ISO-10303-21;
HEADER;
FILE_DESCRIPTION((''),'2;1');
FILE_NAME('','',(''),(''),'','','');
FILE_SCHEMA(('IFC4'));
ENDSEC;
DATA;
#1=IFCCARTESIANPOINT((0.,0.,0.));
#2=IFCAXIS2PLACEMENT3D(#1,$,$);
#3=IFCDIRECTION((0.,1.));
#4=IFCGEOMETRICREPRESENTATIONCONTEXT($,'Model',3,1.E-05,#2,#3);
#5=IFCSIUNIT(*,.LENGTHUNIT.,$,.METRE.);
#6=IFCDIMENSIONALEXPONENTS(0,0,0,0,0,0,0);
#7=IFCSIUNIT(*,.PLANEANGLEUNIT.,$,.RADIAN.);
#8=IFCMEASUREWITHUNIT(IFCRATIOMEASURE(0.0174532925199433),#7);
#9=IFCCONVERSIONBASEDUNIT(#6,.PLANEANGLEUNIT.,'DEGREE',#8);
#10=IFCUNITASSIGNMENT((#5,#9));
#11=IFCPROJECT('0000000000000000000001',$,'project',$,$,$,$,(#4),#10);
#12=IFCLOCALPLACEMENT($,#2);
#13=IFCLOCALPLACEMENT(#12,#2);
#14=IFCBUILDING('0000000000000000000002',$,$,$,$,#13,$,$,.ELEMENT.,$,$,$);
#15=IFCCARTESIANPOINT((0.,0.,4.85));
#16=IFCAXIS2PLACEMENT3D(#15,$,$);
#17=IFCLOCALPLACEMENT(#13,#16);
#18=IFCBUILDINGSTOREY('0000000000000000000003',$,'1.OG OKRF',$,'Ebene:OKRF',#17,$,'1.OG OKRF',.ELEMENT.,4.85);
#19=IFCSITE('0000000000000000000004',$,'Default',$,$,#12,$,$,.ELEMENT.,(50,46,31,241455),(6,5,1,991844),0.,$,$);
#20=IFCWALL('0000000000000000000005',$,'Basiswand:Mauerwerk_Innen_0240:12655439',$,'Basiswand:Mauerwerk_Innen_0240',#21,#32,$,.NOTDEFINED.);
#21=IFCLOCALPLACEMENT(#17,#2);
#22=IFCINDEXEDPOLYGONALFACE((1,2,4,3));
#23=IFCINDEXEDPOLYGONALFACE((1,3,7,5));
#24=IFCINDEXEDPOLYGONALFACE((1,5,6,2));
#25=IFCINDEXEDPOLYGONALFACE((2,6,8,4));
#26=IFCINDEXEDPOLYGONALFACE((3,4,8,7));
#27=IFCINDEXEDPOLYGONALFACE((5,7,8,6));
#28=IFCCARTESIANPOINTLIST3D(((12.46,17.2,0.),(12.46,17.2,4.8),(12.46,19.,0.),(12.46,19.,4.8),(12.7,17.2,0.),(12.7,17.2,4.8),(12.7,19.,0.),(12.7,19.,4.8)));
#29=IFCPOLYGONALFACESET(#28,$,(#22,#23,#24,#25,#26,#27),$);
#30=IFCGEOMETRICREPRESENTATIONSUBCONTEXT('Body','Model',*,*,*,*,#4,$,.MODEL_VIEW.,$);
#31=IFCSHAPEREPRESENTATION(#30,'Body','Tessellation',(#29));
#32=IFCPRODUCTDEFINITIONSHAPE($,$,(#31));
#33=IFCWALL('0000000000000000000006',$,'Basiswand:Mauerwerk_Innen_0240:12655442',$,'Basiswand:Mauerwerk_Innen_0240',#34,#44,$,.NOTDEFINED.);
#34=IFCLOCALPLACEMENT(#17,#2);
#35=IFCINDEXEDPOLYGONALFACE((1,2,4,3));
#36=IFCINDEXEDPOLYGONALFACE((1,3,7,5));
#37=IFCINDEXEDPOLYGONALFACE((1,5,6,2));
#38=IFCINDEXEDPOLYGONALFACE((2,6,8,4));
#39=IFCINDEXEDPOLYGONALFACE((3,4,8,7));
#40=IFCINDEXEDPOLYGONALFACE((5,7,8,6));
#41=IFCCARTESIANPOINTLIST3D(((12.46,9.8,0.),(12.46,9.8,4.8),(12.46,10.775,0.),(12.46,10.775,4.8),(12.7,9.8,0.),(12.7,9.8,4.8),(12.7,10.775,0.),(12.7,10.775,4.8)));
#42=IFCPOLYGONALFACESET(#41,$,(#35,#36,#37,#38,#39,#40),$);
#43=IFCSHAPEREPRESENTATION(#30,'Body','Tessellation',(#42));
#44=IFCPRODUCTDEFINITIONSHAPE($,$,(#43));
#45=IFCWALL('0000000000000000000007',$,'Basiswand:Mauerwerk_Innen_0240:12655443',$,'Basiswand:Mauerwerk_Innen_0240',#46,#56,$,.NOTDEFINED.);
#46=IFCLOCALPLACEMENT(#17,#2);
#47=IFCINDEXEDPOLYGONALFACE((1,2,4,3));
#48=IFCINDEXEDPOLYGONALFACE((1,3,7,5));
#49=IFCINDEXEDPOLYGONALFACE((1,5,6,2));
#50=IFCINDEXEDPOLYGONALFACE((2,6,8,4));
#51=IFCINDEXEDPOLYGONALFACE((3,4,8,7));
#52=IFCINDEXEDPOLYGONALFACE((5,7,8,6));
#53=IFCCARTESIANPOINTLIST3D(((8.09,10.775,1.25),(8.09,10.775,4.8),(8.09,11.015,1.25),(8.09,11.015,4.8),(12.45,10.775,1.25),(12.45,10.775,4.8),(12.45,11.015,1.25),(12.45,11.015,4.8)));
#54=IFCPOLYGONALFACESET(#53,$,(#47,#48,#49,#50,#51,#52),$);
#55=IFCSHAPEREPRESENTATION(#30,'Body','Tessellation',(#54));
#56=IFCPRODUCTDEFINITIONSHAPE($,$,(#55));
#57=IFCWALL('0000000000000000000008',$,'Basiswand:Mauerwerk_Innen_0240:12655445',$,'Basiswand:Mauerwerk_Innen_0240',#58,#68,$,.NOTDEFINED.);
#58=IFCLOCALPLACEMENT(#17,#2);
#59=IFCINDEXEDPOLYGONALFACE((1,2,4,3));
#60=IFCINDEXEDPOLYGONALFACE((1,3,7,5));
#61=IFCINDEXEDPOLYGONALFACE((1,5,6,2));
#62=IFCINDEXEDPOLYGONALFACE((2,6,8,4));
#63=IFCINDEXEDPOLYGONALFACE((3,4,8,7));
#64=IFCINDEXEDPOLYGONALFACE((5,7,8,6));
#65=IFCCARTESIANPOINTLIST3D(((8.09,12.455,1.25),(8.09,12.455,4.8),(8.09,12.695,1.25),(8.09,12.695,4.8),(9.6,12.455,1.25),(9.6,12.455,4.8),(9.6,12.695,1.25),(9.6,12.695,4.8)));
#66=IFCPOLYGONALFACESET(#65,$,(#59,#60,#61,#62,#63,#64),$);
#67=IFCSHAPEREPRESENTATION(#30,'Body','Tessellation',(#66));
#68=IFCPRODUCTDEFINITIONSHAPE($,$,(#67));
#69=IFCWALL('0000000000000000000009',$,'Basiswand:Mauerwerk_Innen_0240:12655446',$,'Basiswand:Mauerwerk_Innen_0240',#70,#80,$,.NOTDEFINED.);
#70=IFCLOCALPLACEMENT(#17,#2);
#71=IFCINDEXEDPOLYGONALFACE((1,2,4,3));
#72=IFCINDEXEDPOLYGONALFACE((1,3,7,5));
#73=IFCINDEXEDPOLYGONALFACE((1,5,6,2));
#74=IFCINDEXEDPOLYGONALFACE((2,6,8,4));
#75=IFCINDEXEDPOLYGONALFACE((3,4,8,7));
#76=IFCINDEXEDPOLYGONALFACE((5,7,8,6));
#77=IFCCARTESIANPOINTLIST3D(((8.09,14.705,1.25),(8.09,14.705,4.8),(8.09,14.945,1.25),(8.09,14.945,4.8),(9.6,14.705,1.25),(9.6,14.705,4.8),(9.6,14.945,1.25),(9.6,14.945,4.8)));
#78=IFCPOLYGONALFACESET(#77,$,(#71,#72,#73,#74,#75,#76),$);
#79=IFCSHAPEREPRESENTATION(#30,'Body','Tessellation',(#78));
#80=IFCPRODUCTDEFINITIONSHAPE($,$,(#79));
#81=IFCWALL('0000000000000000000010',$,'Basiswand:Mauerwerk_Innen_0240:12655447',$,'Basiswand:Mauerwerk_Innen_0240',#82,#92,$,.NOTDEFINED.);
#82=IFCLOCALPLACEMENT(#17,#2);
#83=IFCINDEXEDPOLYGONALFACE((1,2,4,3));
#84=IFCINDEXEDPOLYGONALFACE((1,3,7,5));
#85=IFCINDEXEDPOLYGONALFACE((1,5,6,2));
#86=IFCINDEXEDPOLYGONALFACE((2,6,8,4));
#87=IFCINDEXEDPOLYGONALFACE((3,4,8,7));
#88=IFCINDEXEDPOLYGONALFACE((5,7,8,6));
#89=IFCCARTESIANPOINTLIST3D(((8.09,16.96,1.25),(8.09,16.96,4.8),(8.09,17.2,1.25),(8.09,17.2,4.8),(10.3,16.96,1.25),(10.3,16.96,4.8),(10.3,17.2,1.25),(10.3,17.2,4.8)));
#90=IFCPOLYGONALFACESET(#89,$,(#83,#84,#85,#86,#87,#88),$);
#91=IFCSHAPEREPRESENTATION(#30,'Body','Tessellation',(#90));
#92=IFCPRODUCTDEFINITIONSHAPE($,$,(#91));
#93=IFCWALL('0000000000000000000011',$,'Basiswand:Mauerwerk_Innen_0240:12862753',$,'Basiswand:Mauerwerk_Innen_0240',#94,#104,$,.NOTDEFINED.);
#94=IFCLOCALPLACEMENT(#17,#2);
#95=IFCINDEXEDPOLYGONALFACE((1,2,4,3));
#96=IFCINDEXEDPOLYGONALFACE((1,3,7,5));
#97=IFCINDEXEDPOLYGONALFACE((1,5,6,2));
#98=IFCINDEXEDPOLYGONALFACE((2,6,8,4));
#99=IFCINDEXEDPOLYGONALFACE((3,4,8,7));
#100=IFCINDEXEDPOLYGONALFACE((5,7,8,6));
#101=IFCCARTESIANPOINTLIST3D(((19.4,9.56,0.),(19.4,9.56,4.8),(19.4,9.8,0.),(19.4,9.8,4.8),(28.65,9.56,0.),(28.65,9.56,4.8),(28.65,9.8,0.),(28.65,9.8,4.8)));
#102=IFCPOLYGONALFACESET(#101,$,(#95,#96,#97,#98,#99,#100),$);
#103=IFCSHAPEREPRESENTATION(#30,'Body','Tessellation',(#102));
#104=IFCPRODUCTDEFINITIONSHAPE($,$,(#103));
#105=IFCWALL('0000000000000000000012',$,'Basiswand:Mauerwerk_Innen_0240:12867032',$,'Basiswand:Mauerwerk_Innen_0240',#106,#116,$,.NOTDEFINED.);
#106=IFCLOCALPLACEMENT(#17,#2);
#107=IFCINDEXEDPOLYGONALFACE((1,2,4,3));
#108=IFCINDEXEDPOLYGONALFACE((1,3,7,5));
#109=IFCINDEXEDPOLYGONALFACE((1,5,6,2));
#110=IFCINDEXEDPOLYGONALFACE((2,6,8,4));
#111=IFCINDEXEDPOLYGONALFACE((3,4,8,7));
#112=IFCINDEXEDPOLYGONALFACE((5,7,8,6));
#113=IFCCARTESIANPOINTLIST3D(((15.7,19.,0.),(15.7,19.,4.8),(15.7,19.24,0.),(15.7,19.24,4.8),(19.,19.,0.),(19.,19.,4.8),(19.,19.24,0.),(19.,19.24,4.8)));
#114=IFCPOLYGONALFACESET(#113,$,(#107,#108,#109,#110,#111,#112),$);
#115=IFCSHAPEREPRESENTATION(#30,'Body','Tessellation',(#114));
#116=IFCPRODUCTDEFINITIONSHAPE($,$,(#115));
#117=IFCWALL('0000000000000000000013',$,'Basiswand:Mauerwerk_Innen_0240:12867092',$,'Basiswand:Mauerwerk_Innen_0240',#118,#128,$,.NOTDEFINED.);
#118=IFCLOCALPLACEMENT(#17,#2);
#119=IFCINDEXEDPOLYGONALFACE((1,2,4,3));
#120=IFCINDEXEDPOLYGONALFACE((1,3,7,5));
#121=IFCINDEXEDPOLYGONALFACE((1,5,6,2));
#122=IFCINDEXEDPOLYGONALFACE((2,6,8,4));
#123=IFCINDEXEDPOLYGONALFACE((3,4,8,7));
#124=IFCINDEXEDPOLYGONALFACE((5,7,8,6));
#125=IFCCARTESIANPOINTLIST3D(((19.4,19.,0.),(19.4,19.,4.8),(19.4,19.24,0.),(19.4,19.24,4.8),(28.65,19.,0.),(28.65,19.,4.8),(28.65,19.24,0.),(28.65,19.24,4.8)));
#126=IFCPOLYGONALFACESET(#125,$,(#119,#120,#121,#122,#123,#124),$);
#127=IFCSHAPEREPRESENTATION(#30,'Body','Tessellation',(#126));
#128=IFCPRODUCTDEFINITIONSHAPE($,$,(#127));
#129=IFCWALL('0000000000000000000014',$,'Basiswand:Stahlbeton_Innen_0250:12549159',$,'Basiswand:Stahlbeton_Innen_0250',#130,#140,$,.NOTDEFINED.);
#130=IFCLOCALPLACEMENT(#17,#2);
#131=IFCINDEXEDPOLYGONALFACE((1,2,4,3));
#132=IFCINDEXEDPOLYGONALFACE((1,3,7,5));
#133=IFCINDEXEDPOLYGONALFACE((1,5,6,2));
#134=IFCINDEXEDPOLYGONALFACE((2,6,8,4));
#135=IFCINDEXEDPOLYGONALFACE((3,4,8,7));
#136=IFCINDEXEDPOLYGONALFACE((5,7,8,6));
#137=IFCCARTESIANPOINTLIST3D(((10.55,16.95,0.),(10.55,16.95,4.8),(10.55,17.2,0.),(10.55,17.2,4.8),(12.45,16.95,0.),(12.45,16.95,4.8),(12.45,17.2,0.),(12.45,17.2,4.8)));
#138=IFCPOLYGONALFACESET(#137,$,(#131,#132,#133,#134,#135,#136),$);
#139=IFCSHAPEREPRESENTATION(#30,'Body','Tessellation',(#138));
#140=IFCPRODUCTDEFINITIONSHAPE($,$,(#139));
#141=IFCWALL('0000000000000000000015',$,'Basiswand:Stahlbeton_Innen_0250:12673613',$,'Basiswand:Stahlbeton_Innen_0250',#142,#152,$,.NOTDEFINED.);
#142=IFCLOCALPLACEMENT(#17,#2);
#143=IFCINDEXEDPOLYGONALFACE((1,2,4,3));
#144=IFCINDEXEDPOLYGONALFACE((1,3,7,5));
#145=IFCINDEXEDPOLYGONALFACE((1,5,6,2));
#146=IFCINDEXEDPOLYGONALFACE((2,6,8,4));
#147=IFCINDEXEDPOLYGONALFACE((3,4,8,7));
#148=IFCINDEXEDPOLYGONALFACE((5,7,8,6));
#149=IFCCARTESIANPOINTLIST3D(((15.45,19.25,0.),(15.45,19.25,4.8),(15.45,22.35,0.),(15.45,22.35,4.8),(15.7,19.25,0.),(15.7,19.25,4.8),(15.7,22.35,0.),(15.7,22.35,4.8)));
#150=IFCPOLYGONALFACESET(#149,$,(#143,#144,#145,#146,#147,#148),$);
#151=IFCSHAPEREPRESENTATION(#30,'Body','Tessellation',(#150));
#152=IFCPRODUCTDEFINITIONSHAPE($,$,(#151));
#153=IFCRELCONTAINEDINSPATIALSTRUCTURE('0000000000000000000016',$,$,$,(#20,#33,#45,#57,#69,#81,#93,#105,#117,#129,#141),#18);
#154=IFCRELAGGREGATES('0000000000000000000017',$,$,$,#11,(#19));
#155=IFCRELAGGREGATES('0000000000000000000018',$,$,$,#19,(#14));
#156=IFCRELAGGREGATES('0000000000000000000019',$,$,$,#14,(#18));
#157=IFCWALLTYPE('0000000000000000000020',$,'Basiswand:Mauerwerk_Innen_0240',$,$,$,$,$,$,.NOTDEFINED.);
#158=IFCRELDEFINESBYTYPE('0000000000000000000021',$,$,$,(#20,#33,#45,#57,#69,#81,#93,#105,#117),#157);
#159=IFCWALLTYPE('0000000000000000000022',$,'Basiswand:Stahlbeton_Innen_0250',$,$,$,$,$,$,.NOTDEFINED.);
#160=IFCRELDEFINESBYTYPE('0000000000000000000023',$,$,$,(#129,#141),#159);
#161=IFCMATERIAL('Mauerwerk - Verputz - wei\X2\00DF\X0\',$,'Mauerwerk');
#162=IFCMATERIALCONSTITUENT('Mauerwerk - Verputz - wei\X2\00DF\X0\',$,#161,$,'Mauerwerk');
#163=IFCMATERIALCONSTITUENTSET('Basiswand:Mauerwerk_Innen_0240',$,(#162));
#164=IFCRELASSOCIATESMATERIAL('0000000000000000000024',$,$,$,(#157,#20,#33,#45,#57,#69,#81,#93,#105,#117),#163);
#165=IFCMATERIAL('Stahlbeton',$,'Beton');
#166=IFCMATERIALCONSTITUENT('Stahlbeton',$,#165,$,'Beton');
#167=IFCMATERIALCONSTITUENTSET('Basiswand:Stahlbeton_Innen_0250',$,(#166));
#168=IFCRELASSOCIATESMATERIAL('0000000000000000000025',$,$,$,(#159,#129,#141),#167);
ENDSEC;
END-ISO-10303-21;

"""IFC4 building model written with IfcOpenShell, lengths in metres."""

from ifc_helpers import new_model, entity, si_unit, converted_unit, direction, frame, origin, place, context, subcontext, project, spatial, indexed_curve, outline, extrude, material, constituent, constituent_set, type_object, element, save


model = new_model("IFC4")

# Units and contexts
model_context = context("Model", 3, precision=1e-05, world=origin(), true_north=direction((0.0, 1.0)))
body_context = subcontext(model_context, "Body", "Model", "MODEL_VIEW")
ifc_project = project(units=[si_unit("LENGTHUNIT", "METRE"), converted_unit("PLANEANGLEUNIT", "DEGREE", entity("IfcRatioMeasure", 0.0174532925199433), si_unit("PLANEANGLEUNIT", "RADIAN"), dimensions=[0, 0, 0, 0, 0, 0, 0])], contexts=[model_context])

# Site, building, storey
site_placement = place(None, origin())
site = spatial("IfcSite", under=ifc_project, at=site_placement, Name="Default", CompositionType="ELEMENT", RefLatitude=(50, 46, 31, 241455), RefLongitude=(6, 5, 1, 991844), RefElevation=0.0)
building_placement = place(site_placement, origin())
building = spatial("IfcBuilding", under=site, at=building_placement, CompositionType="ELEMENT")
storey_placement = place(building_placement, frame((0.0, 0.0, 4.85)))
storey = spatial("IfcBuildingStorey", under=building, at=storey_placement, Name="1.OG OKRF", ObjectType="Ebene:OKRF", LongName="1.OG OKRF", CompositionType="ELEMENT", Elevation=4.85)

# Walls
ifc_material_1 = material(Name="Mauerwerk - Verputz - weiß", Category="Mauerwerk")
ifc_constituent_1 = constituent(ifc_material_1, Name="Mauerwerk - Verputz - weiß", Category="Mauerwerk")
ifc_constituent_set_1 = constituent_set(constituents=[ifc_constituent_1], Name="Basiswand:Mauerwerk_Innen_0240")
wall_type_1 = type_object("IfcWallType", Name="Basiswand:Mauerwerk_Innen_0240", PredefinedType="NOTDEFINED", material=ifc_constituent_set_1)
wall_1_placement = place(storey_placement, frame((12.58, 17.2, 0.0), z_axis=(0.0, 0.0, 1.0), x_axis=(0.0, 1.0, 0.0)))
element("IfcWall", 1, at=wall_1_placement, inside=storey, type_object=wall_type_1, material=ifc_constituent_set_1, Name="Basiswand:Mauerwerk_Innen_0240:12655439", ObjectType="Basiswand:Mauerwerk_Innen_0240", PredefinedType="NOTDEFINED", context=body_context, shape_type="SweptSolid", body=[
    extrude(outline(indexed_curve([(-0.12, -0.9), (0.12, -0.9), (0.12, 0.9), (-0.12, 0.9), (-0.12, -0.9)], self_intersect=False)), frame((0.9, 0.0, 0.0), z_axis=(0.0, 0.0, 1.0), x_axis=(0.0, 1.0, 0.0)), (0.0, 0.0, 1.0), 4.8),
])
wall_2_placement = place(storey_placement, frame((12.58, 9.8, 0.0), z_axis=(0.0, 0.0, 1.0), x_axis=(0.0, 1.0, 0.0)))
element("IfcWall", 2, at=wall_2_placement, inside=storey, type_object=wall_type_1, material=ifc_constituent_set_1, Name="Basiswand:Mauerwerk_Innen_0240:12655442", ObjectType="Basiswand:Mauerwerk_Innen_0240", PredefinedType="NOTDEFINED", context=body_context, shape_type="SweptSolid", body=[
    extrude(outline(indexed_curve([(-0.12, -0.4875), (0.12, -0.4875), (0.12, 0.4875), (-0.12, 0.4875), (-0.12, -0.4875)], self_intersect=False)), frame((0.4875, 0.0, 0.0), z_axis=(0.0, 0.0, 1.0), x_axis=(0.0, 1.0, 0.0)), (0.0, 0.0, 1.0), 4.8),
])
wall_3_placement = place(storey_placement, frame((12.45, 10.895, 1.25), z_axis=(0.0, 0.0, 1.0), x_axis=(-1.0, 0.0, 0.0)))
element("IfcWall", 3, at=wall_3_placement, inside=storey, type_object=wall_type_1, material=ifc_constituent_set_1, Name="Basiswand:Mauerwerk_Innen_0240:12655443", ObjectType="Basiswand:Mauerwerk_Innen_0240", PredefinedType="NOTDEFINED", context=body_context, shape_type="SweptSolid", body=[
    extrude(outline(indexed_curve([(-0.12, -2.18), (0.12, -2.18), (0.12, 2.18), (-0.12, 2.18), (-0.12, -2.18)], self_intersect=False)), frame((2.18, 0.0, 0.0), z_axis=(0.0, 0.0, 1.0), x_axis=(0.0, 1.0, 0.0)), (0.0, 0.0, 1.0), 3.55),
])
wall_4_placement = place(storey_placement, frame((9.6, 12.575, 1.25), z_axis=(0.0, 0.0, 1.0), x_axis=(-1.0, 0.0, 0.0)))
element("IfcWall", 4, at=wall_4_placement, inside=storey, type_object=wall_type_1, material=ifc_constituent_set_1, Name="Basiswand:Mauerwerk_Innen_0240:12655445", ObjectType="Basiswand:Mauerwerk_Innen_0240", PredefinedType="NOTDEFINED", context=body_context, shape_type="SweptSolid", body=[
    extrude(outline(indexed_curve([(-0.12, -0.755), (0.12, -0.755), (0.12, 0.755), (-0.12, 0.755), (-0.12, -0.755)], self_intersect=False)), frame((0.755, 0.0, 0.0), z_axis=(0.0, 0.0, 1.0), x_axis=(0.0, 1.0, 0.0)), (0.0, 0.0, 1.0), 3.55),
])
wall_5_placement = place(storey_placement, frame((9.6, 14.825, 1.25), z_axis=(0.0, 0.0, 1.0), x_axis=(-1.0, 0.0, 0.0)))
element("IfcWall", 5, at=wall_5_placement, inside=storey, type_object=wall_type_1, material=ifc_constituent_set_1, Name="Basiswand:Mauerwerk_Innen_0240:12655446", ObjectType="Basiswand:Mauerwerk_Innen_0240", PredefinedType="NOTDEFINED", context=body_context, shape_type="SweptSolid", body=[
    extrude(outline(indexed_curve([(-0.12, -0.755), (0.12, -0.755), (0.12, 0.755), (-0.12, 0.755), (-0.12, -0.755)], self_intersect=False)), frame((0.755, 0.0, 0.0), z_axis=(0.0, 0.0, 1.0), x_axis=(0.0, 1.0, 0.0)), (0.0, 0.0, 1.0), 3.55),
])
wall_6_placement = place(storey_placement, frame((10.3, 17.08, 1.25), z_axis=(0.0, 0.0, 1.0), x_axis=(-1.0, 0.0, 0.0)))
element("IfcWall", 6, at=wall_6_placement, inside=storey, type_object=wall_type_1, material=ifc_constituent_set_1, Name="Basiswand:Mauerwerk_Innen_0240:12655447", ObjectType="Basiswand:Mauerwerk_Innen_0240", PredefinedType="NOTDEFINED", context=body_context, shape_type="SweptSolid", body=[
    extrude(outline(indexed_curve([(-0.12, -1.105), (0.12, -1.105), (0.12, 1.105), (-0.12, 1.105), (-0.12, -1.105)], self_intersect=False)), frame((1.105, 0.0, 0.0), z_axis=(0.0, 0.0, 1.0), x_axis=(0.0, 1.0, 0.0)), (0.0, 0.0, 1.0), 3.55),
])
wall_7_placement = place(storey_placement, frame((19.4, 9.68, 0.0)))
element("IfcWall", 7, at=wall_7_placement, inside=storey, type_object=wall_type_1, material=ifc_constituent_set_1, Name="Basiswand:Mauerwerk_Innen_0240:12862753", ObjectType="Basiswand:Mauerwerk_Innen_0240", PredefinedType="NOTDEFINED", context=body_context, shape_type="SweptSolid", body=[
    extrude(outline(indexed_curve([(-0.12, -4.625), (0.12, -4.625), (0.12, 4.625), (-0.12, 4.625), (-0.12, -4.625)], self_intersect=False)), frame((4.625, 0.0, 0.0), z_axis=(0.0, 0.0, 1.0), x_axis=(0.0, 1.0, 0.0)), (0.0, 0.0, 1.0), 4.8),
])
wall_8_placement = place(storey_placement, frame((15.7, 19.12, 0.0)))
element("IfcWall", 8, at=wall_8_placement, inside=storey, type_object=wall_type_1, material=ifc_constituent_set_1, Name="Basiswand:Mauerwerk_Innen_0240:12867032", ObjectType="Basiswand:Mauerwerk_Innen_0240", PredefinedType="NOTDEFINED", context=body_context, shape_type="SweptSolid", body=[
    extrude(outline(indexed_curve([(-0.12, -1.65), (0.12, -1.65), (0.12, 1.65), (-0.12, 1.65), (-0.12, -1.65)], self_intersect=False)), frame((1.65, 0.0, 0.0), z_axis=(0.0, 0.0, 1.0), x_axis=(0.0, 1.0, 0.0)), (0.0, 0.0, 1.0), 4.8),
])
wall_9_placement = place(storey_placement, frame((19.4, 19.12, 0.0)))
element("IfcWall", 9, at=wall_9_placement, inside=storey, type_object=wall_type_1, material=ifc_constituent_set_1, Name="Basiswand:Mauerwerk_Innen_0240:12867092", ObjectType="Basiswand:Mauerwerk_Innen_0240", PredefinedType="NOTDEFINED", context=body_context, shape_type="SweptSolid", body=[
    extrude(outline(indexed_curve([(-0.12, -4.625), (0.12, -4.625), (0.12, 4.625), (-0.12, 4.625), (-0.12, -4.625)], self_intersect=False)), frame((4.625, 0.0, 0.0), z_axis=(0.0, 0.0, 1.0), x_axis=(0.0, 1.0, 0.0)), (0.0, 0.0, 1.0), 4.8),
])
ifc_material_2 = material(Name="Stahlbeton", Category="Beton")
ifc_constituent_2 = constituent(ifc_material_2, Name="Stahlbeton", Category="Beton")
ifc_constituent_set_2 = constituent_set(constituents=[ifc_constituent_2], Name="Basiswand:Stahlbeton_Innen_0250")
wall_type_2 = type_object("IfcWallType", Name="Basiswand:Stahlbeton_Innen_0250", PredefinedType="NOTDEFINED", material=ifc_constituent_set_2)
wall_10_placement = place(storey_placement, frame((12.45, 17.075, 0.0), z_axis=(0.0, 0.0, 1.0), x_axis=(-1.0, 0.0, 0.0)))
element("IfcWall", 10, at=wall_10_placement, inside=storey, type_object=wall_type_2, material=ifc_constituent_set_2, Name="Basiswand:Stahlbeton_Innen_0250:12549159", ObjectType="Basiswand:Stahlbeton_Innen_0250", PredefinedType="NOTDEFINED", context=body_context, shape_type="SweptSolid", body=[
    extrude(outline(indexed_curve([(-0.125, -0.95), (0.125, -0.95), (0.125, 0.95), (-0.125, 0.95), (-0.125, -0.95)], self_intersect=False)), frame((0.95, 0.0, 0.0), z_axis=(0.0, 0.0, 1.0), x_axis=(0.0, 1.0, 0.0)), (0.0, 0.0, 1.0), 4.8),
])
wall_11_placement = place(storey_placement, frame((15.575, 22.35, 0.0), z_axis=(0.0, 0.0, 1.0), x_axis=(0.0, -1.0, 0.0)))
element("IfcWall", 11, at=wall_11_placement, inside=storey, type_object=wall_type_2, material=ifc_constituent_set_2, Name="Basiswand:Stahlbeton_Innen_0250:12673613", ObjectType="Basiswand:Stahlbeton_Innen_0250", PredefinedType="NOTDEFINED", context=body_context, shape_type="SweptSolid", body=[
    extrude(outline(indexed_curve([(-0.125, -1.55), (0.125, -1.55), (0.125, 1.55), (-0.125, 1.55), (-0.125, -1.55)], self_intersect=False)), frame((1.55, 0.0, 0.0), z_axis=(0.0, 0.0, 1.0), x_axis=(0.0, 1.0, 0.0)), (0.0, 0.0, 1.0), 4.8),
])

save(model, "model.ifc")
